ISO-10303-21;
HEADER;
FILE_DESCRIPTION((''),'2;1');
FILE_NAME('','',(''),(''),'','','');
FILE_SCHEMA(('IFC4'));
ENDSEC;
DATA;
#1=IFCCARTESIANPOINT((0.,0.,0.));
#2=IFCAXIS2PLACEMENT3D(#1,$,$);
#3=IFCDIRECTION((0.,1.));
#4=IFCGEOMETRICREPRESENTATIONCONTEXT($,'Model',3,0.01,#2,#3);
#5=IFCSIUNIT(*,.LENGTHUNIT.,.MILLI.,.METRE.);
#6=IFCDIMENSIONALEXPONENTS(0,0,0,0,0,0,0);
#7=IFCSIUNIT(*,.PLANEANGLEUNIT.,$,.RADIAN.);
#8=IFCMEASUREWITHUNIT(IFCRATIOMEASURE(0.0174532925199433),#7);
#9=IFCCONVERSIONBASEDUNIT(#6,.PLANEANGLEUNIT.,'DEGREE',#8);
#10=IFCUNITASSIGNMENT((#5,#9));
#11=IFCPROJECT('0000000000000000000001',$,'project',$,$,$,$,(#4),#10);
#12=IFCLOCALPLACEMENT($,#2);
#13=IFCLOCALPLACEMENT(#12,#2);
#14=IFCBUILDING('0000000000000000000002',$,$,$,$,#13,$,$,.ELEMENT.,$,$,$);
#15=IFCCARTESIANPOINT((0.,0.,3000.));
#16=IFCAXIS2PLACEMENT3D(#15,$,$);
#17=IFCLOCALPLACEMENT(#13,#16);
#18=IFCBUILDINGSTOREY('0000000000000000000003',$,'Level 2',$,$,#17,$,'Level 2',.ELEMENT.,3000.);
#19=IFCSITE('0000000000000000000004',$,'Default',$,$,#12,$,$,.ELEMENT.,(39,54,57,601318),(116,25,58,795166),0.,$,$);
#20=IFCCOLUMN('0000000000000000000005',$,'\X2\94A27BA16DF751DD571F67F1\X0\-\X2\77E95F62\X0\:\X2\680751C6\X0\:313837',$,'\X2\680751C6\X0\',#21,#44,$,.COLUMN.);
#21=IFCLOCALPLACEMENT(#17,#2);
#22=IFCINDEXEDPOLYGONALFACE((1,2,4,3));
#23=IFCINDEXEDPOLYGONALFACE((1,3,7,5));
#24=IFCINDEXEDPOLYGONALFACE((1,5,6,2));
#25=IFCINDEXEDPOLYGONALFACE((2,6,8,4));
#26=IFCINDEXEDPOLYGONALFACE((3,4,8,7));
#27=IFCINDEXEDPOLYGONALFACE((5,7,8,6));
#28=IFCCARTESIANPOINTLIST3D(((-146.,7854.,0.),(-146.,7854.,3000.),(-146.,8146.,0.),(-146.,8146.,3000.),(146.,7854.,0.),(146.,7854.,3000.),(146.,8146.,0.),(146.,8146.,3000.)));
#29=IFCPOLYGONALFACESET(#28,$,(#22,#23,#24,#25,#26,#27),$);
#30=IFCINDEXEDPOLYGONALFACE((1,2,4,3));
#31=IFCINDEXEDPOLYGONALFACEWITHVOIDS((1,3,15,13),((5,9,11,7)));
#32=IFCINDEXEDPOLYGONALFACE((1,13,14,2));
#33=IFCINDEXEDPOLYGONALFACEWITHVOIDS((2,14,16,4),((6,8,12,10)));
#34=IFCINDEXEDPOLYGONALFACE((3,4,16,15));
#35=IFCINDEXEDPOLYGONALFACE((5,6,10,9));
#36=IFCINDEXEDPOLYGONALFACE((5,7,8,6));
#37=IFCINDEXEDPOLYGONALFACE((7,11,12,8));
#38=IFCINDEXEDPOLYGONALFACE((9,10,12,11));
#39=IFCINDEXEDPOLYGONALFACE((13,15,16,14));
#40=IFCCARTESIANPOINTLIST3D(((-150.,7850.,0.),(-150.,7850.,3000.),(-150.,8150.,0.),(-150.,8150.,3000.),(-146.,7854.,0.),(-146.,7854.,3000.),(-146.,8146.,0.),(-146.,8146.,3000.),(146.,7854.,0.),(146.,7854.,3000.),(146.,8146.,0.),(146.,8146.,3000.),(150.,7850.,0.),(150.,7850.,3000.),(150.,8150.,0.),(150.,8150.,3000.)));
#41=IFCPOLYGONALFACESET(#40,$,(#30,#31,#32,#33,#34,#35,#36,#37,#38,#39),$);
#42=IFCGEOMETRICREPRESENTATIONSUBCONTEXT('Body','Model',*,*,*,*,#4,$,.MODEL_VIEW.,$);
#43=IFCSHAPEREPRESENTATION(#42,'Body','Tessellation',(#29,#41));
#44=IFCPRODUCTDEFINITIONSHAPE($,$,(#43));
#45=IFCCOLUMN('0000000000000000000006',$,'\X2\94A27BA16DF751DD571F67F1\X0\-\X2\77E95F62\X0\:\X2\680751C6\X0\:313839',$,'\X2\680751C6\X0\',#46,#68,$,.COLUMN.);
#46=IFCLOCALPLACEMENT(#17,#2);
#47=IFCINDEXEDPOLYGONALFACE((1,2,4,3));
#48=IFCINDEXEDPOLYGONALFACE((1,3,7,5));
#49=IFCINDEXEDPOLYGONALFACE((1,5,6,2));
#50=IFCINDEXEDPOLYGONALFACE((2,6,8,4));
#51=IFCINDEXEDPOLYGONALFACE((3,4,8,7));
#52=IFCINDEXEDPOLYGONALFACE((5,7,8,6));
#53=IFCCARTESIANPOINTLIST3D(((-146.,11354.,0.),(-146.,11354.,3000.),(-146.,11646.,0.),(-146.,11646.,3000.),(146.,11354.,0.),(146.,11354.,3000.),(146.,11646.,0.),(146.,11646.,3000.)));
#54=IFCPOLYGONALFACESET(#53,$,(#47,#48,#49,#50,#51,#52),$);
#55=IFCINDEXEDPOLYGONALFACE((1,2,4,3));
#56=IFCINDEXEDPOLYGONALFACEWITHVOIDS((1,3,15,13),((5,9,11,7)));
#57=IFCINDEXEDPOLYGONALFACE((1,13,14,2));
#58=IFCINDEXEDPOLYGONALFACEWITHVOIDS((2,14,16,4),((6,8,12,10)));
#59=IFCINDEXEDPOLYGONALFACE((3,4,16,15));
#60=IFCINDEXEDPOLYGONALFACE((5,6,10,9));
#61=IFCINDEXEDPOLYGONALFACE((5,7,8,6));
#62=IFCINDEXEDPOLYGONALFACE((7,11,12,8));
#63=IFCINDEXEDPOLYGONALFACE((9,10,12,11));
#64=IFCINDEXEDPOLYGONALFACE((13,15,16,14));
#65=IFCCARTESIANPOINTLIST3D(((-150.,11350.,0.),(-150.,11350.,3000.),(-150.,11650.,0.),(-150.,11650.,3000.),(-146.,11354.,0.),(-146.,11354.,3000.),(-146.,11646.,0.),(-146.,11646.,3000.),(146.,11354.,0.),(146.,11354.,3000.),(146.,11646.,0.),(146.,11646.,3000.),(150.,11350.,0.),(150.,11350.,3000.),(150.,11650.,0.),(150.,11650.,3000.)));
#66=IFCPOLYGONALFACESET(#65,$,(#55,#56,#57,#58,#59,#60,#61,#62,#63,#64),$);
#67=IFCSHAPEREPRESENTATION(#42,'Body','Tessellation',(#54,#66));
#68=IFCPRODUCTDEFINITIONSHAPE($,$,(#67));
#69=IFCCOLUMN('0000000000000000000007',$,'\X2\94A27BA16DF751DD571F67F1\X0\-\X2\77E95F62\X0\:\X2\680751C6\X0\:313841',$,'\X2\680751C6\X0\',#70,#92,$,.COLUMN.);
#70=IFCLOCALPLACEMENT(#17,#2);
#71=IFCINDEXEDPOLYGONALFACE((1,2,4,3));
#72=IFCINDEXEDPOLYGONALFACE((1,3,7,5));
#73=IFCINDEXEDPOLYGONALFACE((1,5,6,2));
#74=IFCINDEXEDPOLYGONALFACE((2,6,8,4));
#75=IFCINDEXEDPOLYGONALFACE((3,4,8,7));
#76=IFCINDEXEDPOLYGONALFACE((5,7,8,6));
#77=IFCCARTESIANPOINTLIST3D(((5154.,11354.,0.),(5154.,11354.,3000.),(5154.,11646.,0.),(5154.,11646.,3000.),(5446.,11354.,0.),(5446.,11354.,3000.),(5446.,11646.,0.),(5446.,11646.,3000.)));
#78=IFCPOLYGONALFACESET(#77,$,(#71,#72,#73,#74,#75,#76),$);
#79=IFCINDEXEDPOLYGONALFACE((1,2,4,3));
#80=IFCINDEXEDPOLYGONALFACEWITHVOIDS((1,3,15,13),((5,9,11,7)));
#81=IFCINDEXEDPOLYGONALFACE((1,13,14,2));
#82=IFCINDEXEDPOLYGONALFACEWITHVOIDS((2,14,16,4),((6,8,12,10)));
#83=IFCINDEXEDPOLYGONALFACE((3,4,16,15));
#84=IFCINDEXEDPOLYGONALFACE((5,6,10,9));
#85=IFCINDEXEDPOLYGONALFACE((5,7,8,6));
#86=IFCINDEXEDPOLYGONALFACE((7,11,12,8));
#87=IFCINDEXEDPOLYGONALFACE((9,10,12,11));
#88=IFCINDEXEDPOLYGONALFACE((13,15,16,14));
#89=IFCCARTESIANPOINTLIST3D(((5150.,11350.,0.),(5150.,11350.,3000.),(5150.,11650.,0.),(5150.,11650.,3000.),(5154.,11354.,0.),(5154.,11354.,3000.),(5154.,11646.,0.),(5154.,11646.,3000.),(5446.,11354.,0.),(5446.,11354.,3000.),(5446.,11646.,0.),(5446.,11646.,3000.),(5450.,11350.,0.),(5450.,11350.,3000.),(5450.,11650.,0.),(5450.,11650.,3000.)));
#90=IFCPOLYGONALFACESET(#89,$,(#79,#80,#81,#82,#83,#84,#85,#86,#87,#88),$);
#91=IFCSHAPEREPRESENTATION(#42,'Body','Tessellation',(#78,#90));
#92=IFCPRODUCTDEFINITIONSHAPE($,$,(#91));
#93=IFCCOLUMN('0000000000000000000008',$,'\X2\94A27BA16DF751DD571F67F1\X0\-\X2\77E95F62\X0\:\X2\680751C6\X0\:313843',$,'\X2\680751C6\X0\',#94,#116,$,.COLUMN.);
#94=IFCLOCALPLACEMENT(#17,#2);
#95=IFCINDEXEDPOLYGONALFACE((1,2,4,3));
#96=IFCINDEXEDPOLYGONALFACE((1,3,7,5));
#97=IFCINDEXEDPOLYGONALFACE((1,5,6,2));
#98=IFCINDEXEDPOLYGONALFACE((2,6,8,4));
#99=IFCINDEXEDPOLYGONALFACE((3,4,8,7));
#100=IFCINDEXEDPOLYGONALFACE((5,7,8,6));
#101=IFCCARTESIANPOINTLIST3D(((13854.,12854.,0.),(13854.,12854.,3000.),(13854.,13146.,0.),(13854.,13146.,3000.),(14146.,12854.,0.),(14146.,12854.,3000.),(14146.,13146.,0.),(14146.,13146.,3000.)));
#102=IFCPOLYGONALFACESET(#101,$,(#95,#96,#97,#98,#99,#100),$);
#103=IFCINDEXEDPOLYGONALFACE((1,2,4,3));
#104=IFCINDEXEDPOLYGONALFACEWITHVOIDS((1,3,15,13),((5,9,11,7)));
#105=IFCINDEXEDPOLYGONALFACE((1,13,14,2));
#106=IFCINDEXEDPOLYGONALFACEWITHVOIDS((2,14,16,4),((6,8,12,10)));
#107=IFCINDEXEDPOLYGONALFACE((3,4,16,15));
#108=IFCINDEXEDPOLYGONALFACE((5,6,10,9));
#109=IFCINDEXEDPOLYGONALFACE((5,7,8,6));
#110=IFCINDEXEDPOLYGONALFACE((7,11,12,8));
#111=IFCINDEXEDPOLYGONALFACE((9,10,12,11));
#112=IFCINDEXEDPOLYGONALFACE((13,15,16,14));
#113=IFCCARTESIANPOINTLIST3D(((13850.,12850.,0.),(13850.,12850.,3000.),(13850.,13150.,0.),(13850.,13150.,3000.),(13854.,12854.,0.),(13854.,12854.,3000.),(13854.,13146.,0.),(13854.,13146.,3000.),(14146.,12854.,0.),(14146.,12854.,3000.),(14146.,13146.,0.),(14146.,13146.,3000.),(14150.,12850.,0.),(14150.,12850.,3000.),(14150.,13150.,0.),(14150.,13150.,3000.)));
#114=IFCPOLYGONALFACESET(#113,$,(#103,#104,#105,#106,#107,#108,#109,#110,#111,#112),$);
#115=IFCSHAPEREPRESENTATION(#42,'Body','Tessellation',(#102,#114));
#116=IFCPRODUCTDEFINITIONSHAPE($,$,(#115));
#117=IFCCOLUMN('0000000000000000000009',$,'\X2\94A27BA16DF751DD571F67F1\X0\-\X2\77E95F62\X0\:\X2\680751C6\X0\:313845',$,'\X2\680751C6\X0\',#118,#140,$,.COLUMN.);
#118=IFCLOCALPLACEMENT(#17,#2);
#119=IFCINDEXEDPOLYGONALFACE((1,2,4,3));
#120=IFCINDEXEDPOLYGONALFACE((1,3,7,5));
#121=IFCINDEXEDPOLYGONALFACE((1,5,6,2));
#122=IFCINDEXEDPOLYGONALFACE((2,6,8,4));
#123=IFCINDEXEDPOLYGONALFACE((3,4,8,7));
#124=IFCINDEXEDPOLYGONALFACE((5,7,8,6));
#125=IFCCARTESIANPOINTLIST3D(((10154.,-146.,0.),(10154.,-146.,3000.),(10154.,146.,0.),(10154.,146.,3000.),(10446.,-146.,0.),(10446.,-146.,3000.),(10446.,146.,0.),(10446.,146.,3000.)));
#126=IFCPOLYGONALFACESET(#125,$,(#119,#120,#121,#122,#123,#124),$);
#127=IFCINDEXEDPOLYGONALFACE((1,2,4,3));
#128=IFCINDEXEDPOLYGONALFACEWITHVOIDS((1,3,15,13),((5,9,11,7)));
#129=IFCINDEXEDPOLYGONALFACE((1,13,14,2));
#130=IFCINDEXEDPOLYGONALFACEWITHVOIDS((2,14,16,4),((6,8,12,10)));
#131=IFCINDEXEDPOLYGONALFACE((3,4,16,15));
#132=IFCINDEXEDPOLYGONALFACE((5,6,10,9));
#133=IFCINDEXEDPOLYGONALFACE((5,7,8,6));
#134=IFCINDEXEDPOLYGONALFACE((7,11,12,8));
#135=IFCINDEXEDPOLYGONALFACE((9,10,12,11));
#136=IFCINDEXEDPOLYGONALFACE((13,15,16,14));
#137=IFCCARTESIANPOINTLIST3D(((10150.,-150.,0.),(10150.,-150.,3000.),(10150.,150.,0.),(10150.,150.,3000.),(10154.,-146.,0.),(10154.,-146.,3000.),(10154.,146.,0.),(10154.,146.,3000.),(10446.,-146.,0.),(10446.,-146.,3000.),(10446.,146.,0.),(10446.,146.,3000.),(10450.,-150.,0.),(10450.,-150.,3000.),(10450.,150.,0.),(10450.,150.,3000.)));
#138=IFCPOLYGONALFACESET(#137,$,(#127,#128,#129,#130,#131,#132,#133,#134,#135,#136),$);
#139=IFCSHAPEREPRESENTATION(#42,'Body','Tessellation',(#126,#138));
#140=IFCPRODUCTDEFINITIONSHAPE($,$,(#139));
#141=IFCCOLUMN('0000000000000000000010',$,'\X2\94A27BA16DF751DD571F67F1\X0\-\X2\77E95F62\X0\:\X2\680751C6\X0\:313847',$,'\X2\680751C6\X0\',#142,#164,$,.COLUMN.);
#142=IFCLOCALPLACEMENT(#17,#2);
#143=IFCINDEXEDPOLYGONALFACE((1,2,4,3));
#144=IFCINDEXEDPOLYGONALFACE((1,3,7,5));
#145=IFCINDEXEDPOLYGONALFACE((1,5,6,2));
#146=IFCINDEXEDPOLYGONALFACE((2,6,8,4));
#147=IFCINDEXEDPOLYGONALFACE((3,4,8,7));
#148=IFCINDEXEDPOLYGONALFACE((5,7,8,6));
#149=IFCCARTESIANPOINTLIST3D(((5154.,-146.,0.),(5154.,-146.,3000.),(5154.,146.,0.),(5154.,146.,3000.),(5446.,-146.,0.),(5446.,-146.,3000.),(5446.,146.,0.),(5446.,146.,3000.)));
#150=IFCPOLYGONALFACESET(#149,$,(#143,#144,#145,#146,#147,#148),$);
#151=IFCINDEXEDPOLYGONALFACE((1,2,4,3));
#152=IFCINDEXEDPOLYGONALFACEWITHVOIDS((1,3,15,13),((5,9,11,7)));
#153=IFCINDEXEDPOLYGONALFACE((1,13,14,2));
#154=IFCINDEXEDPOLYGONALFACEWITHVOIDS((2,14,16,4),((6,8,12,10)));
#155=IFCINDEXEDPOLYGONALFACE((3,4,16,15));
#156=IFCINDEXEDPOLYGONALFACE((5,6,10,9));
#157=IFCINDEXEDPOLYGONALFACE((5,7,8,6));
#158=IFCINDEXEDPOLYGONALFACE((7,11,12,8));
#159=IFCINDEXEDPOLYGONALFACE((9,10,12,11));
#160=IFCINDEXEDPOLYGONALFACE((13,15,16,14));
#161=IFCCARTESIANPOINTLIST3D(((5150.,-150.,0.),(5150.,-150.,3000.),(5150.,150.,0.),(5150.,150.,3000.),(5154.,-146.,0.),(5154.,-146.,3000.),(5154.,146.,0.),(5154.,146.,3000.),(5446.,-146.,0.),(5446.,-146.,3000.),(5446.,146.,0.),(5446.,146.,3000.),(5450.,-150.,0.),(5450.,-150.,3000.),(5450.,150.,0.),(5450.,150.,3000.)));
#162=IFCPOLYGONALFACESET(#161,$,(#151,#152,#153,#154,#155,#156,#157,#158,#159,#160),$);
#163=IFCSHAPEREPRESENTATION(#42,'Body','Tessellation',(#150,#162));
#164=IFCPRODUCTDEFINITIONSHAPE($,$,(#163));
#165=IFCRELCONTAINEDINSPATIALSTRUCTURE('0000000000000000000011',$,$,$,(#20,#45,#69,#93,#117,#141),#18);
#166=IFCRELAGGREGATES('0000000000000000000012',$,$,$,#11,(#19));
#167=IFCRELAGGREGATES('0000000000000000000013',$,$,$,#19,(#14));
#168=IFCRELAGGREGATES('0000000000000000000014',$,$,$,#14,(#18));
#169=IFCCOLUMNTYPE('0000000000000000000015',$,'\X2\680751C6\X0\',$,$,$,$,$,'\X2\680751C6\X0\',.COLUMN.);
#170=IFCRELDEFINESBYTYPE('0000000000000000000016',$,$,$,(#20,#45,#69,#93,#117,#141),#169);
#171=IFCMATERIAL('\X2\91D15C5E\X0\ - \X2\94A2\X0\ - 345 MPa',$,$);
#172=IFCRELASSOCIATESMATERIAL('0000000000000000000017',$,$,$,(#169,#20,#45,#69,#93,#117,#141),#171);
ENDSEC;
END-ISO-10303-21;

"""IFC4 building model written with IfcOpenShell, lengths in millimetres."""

from ifc_helpers import new_model, entity, si_unit, converted_unit, direction, frame, origin, origin_2d_with_axis, place, context, subcontext, project, spatial, polyline, rectangle, outline, extrude, source, transform, mapped, material, type_object, type_shapes, element, save


model = new_model("IFC4")

# Units and contexts
model_context = context("Model", 3, precision=0.01, world=origin(), true_north=direction((0.0, 1.0)))
body_context = subcontext(model_context, "Body", "Model", "MODEL_VIEW")
ifc_project = project(units=[si_unit("LENGTHUNIT", "METRE", prefix="MILLI"), converted_unit("PLANEANGLEUNIT", "DEGREE", entity("IfcRatioMeasure", 0.0174532925199433), si_unit("PLANEANGLEUNIT", "RADIAN"), dimensions=[0, 0, 0, 0, 0, 0, 0])], contexts=[model_context])

# Site, building, storey
site_placement = place(None, origin())
site = spatial("IfcSite", under=ifc_project, at=site_placement, Name="Default", CompositionType="ELEMENT", RefLatitude=(39, 54, 57, 601318), RefLongitude=(116, 25, 58, 795166), RefElevation=0.0)
building_placement = place(site_placement, origin())
building = spatial("IfcBuilding", under=site, at=building_placement, CompositionType="ELEMENT")
storey_placement = place(building_placement, frame((0.0, 0.0, 3000.0)))
storey = spatial("IfcBuildingStorey", under=building, at=storey_placement, Name="Level 2", LongName="Level 2", CompositionType="ELEMENT", Elevation=3000.0)

# Columns
ifc_material = material(Name="金属 - 钢 - 345 MPa")
column_type = type_object("IfcColumnType", Name="标准", ElementType="标准", PredefinedType="COLUMN", material=ifc_material)
shared_shape = source(origin(), body_context, "Body", "SweptSolid", [
    extrude(rectangle(XDim=292.0, YDim=292.0, at=origin_2d_with_axis()), frame((150.0, 150.0, 0.0), z_axis=(0.0, 0.0, 1.0), x_axis=(-1.0, 0.0, 0.0)), (0.0, 0.0, 1.0), 3000.0),
    extrude(outline(polyline([(-150.0, -150.0), (150.0, -150.0), (150.0, 150.0), (-150.0, 150.0), (-150.0, -150.0)]), holes=[polyline([(-146.0, -146.0), (-146.0, 146.0), (146.0, 146.0), (146.0, -146.0), (-146.0, -146.0)])]), frame((150.0, 150.0, 0.0), z_axis=(0.0, 0.0, 1.0), x_axis=(-1.0, 0.0, 0.0)), (0.0, 0.0, 1.0), 3000.0),
])
type_shapes(column_type, [shared_shape])
for number, where, name in (
    (1, (-150.0, 7850.0, 0.0), "钢管混凝土柱-矩形:标准:313837"),
    (2, (-150.0, 11350.0, 0.0), "钢管混凝土柱-矩形:标准:313839"),
    (3, (5150.0, 11350.0, 0.0), "钢管混凝土柱-矩形:标准:313841"),
    (4, (13850.0, 12850.0, 0.0), "钢管混凝土柱-矩形:标准:313843"),
    (5, (10150.0, -150.0, 0.0), "钢管混凝土柱-矩形:标准:313845"),
    (6, (5150.0, -150.0, 0.0), "钢管混凝土柱-矩形:标准:313847"),
):
    element("IfcColumn", number, at=place(storey_placement, frame(where)), inside=storey, type_object=column_type, material=ifc_material, Name=name, ObjectType="标准", PredefinedType="COLUMN", context=body_context, shape_type="MappedRepresentation", body=[
        mapped(shared_shape, transform((0.0, 0.0, 0.0), scale=1.0)),
    ])

save(model, "model.ifc")
